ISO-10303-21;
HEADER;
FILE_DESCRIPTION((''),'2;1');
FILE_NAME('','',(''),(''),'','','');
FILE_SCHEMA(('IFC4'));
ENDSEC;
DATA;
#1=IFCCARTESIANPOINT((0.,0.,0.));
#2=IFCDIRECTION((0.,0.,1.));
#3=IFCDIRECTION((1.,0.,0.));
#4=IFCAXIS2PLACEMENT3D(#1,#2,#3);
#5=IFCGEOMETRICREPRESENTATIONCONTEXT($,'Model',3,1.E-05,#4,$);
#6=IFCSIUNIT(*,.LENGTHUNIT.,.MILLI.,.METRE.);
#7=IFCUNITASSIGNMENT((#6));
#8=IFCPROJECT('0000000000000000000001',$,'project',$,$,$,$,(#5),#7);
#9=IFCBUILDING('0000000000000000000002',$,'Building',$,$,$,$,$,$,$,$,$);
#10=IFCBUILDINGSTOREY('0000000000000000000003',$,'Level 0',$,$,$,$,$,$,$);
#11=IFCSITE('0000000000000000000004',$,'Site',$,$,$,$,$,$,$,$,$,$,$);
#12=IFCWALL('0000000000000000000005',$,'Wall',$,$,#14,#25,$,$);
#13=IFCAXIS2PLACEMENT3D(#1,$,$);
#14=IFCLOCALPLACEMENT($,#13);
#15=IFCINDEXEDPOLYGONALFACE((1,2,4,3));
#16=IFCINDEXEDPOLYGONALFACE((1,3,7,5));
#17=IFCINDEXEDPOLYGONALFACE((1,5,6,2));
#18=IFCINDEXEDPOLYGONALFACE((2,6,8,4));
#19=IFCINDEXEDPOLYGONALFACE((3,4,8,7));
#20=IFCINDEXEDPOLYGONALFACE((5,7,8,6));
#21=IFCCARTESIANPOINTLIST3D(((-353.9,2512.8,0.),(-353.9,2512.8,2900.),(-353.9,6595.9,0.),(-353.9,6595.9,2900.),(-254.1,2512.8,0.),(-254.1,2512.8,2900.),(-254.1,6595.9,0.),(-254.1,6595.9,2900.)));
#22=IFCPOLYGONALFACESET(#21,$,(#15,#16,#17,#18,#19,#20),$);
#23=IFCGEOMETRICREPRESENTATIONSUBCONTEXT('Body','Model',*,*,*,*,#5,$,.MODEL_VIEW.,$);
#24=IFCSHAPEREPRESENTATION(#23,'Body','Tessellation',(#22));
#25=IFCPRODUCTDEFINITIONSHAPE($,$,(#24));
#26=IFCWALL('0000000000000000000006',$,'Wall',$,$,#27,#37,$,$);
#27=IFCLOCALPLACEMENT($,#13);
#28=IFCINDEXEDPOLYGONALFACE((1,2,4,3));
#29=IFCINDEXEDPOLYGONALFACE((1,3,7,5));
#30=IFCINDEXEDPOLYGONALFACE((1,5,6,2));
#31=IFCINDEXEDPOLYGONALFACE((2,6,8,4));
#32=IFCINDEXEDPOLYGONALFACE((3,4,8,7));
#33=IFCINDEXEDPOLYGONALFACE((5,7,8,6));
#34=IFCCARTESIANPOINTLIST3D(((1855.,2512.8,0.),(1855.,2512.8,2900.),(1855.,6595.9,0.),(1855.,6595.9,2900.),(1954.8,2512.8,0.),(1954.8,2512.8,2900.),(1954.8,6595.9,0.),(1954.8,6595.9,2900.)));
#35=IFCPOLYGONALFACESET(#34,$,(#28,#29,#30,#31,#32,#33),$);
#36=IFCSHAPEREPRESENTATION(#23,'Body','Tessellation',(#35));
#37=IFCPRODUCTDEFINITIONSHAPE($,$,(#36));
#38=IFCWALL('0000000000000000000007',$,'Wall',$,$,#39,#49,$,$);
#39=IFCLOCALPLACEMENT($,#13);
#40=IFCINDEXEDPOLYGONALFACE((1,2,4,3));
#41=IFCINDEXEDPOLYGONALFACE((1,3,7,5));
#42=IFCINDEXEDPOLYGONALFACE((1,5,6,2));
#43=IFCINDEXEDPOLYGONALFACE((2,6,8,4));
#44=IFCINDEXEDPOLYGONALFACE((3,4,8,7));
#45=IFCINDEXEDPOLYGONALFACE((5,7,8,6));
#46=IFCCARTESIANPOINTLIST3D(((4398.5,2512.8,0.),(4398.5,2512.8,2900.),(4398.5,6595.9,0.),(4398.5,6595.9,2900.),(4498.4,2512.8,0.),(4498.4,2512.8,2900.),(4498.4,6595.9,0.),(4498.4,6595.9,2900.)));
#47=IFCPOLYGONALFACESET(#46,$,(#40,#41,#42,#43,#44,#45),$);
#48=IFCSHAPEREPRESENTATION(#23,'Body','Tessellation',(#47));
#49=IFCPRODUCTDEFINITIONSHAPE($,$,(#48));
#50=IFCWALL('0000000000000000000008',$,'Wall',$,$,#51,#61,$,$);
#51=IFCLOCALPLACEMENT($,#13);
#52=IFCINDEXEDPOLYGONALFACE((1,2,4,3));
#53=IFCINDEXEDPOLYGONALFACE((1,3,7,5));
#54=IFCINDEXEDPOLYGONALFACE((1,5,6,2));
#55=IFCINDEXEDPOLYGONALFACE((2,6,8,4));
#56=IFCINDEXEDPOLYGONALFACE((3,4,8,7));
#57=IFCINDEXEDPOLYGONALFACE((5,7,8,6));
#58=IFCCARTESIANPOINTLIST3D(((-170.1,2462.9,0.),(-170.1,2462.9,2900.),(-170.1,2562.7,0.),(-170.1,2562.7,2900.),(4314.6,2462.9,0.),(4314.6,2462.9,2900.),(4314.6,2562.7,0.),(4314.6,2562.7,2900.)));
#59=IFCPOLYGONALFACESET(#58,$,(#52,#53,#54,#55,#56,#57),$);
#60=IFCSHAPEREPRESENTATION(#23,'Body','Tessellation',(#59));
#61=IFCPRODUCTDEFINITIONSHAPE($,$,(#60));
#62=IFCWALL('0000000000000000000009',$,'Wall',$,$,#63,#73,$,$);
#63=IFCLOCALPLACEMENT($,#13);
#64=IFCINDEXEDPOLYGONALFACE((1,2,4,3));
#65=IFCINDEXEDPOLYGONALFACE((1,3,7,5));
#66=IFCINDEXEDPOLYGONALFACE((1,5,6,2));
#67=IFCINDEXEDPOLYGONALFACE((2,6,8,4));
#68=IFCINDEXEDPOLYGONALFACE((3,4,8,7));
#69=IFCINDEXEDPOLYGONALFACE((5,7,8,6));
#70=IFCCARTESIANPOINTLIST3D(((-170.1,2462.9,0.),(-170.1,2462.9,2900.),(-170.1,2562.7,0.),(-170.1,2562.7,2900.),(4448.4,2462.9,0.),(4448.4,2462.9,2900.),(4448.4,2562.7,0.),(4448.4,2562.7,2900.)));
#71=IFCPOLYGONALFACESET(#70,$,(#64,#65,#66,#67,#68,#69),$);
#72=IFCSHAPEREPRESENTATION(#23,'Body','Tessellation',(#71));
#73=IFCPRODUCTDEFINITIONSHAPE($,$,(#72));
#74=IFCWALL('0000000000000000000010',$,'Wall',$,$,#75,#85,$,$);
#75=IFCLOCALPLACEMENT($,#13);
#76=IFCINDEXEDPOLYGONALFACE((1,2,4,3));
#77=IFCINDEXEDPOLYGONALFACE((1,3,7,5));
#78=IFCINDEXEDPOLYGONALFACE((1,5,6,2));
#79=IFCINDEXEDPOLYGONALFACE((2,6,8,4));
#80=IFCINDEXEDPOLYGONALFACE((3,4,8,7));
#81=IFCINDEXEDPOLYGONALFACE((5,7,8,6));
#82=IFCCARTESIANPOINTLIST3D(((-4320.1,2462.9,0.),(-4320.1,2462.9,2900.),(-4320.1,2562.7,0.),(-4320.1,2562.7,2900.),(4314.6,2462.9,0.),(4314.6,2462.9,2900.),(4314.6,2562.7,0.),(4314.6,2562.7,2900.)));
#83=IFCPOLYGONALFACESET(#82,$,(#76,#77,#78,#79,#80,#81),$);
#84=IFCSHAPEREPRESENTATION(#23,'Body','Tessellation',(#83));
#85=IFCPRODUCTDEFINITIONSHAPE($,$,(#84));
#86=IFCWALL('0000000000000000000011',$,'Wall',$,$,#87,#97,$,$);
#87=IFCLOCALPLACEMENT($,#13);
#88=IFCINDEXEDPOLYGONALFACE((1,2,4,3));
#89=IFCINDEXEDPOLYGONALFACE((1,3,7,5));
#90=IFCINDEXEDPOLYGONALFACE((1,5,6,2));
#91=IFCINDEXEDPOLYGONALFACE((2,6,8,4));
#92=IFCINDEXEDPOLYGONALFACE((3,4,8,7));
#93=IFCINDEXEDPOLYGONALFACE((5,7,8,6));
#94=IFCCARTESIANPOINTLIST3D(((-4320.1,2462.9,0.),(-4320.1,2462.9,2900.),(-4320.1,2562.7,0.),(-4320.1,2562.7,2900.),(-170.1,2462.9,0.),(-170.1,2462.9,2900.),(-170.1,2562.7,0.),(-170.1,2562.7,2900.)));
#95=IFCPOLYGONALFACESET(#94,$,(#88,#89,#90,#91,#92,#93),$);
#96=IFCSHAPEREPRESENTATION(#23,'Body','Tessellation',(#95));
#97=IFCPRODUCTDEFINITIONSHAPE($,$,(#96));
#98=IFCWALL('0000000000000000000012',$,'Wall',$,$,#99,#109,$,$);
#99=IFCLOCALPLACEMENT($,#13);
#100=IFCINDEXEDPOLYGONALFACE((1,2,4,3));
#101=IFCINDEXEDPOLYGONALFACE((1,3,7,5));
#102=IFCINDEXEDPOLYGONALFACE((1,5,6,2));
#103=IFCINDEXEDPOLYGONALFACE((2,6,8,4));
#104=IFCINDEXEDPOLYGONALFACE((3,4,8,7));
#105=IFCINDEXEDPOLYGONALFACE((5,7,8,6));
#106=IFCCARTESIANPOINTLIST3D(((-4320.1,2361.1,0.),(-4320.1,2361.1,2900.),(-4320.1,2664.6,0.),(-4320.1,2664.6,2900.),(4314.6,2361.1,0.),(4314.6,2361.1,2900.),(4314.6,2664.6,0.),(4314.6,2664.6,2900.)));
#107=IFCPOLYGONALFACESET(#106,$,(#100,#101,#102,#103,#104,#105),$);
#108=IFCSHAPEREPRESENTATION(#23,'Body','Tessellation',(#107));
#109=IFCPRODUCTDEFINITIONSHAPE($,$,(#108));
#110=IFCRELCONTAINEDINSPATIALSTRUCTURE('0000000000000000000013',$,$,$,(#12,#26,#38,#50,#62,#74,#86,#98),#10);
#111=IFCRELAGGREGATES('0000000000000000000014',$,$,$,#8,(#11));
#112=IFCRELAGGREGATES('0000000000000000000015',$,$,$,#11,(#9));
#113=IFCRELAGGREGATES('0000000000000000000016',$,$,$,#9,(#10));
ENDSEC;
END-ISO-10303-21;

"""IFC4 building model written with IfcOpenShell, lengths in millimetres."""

from ifc_helpers import new_model, si_unit, frame, origin_with_axes, place, context, subcontext, project, spatial, indexed_curve, outline, extrude, element, save


model = new_model("IFC4")

# Units and contexts
model_context = context("Model", 3, precision=1e-05, world=origin_with_axes())
body_context = subcontext(model_context, "Body", "Model", "MODEL_VIEW")
ifc_project = project(units=[si_unit("LENGTHUNIT", "METRE", prefix="MILLI")], contexts=[model_context])

# Site, building, storey
site = spatial("IfcSite", under=ifc_project, Name="Site")
building = spatial("IfcBuilding", under=site, Name="Building")
storey = spatial("IfcBuildingStorey", under=building, Name="Level 0")

# Walls
for number, where, z_axis, x_axis, name in (
    (1, (-353.9, 6595.9, 0.0), (0.0, 0.0, 1.0), (0.0, -1.0, 0.0), "Wall"),
    (2, (1855.0, 6595.9, 0.0), (0.0, 0.0, 1.0), (0.0, -1.0, 0.0), "Wall"),
    (3, (4398.5, 6595.9, 0.0), (0.0, 0.0, 1.0), (0.0, -1.0, 0.0), "Wall"),
):
    element("IfcWall", number, at=place(None, frame(where, z_axis=z_axis, x_axis=x_axis)), inside=storey, Name=name, context=body_context, shape_type="SweptSolid", body=[
        extrude(outline(indexed_curve([(0.0, 0.0), (0.0, 99.8), (4083.1, 99.8), (4083.1, 0.0), (0.0, 0.0)], self_intersect=False)), origin_with_axes(), (0.0, 0.0, 1.0), 2900.0),
    ])
for number, where, z_axis, x_axis, name in (
    (4, (-170.1, 2462.9, 0.0), (0.0, 0.0, 1.0), (1.0, 0.0, 0.0), "Wall"),
):
    element("IfcWall", number, at=place(None, frame(where, z_axis=z_axis, x_axis=x_axis)), inside=storey, Name=name, context=body_context, shape_type="SweptSolid", body=[
        extrude(outline(indexed_curve([(0.0, 0.0), (0.0, 99.8), (4484.7, 99.8), (4484.7, 0.0), (0.0, 0.0)], self_intersect=False)), origin_with_axes(), (0.0, 0.0, 1.0), 2900.0),
    ])
wall_1_placement = place(None, frame((4448.4, 2562.7, 0.0), z_axis=(0.0, 0.0, 1.0), x_axis=(-1.0, 0.0, 0.0)))
element("IfcWall", 5, at=wall_1_placement, inside=storey, Name="Wall", context=body_context, shape_type="SweptSolid", body=[
    extrude(outline(indexed_curve([(0.0, 0.0), (0.0, 99.8), (4618.5, 99.8), (4618.5, 0.0), (0.0, 0.0)], self_intersect=False)), origin_with_axes(), (0.0, 0.0, 1.0), 2900.0),
])
wall_2_placement = place(None, frame((-4320.1, 2462.9, 0.0), z_axis=(0.0, 0.0, 1.0), x_axis=(1.0, 0.0, 0.0)))
element("IfcWall", 6, at=wall_2_placement, inside=storey, Name="Wall", context=body_context, shape_type="SweptSolid", body=[
    extrude(outline(indexed_curve([(0.0, 0.0), (0.0, 99.8), (8634.7, 99.8), (8634.7, 0.0), (0.0, 0.0)], self_intersect=False)), origin_with_axes(), (0.0, 0.0, 1.0), 2900.0),
])
for number, where, z_axis, x_axis, name in (
    (7, (-4320.1, 2462.9, 0.0), (0.0, 0.0, 1.0), (1.0, 0.0, 0.0), "Wall"),
):
    element("IfcWall", number, at=place(None, frame(where, z_axis=z_axis, x_axis=x_axis)), inside=storey, Name=name, context=body_context, shape_type="SweptSolid", body=[
        extrude(outline(indexed_curve([(0.0, 0.0), (0.0, 99.8), (4150.0, 99.8), (4150.0, 0.0), (0.0, 0.0)], self_intersect=False)), origin_with_axes(), (0.0, 0.0, 1.0), 2900.0),
    ])
wall_3_placement = place(None, frame((-4320.1, 2361.1, 0.0), z_axis=(0.0, 0.0, 1.0), x_axis=(1.0, 0.0, 0.0)))
element("IfcWall", 8, at=wall_3_placement, inside=storey, Name="Wall", context=body_context, shape_type="SweptSolid", body=[
    extrude(outline(indexed_curve([(0.0, 0.0), (0.0, 303.4), (8634.7, 303.4), (8634.7, 0.0), (0.0, 0.0)], self_intersect=False)), origin_with_axes(), (0.0, 0.0, 1.0), 2900.0),
])

save(model, "model.ifc")
